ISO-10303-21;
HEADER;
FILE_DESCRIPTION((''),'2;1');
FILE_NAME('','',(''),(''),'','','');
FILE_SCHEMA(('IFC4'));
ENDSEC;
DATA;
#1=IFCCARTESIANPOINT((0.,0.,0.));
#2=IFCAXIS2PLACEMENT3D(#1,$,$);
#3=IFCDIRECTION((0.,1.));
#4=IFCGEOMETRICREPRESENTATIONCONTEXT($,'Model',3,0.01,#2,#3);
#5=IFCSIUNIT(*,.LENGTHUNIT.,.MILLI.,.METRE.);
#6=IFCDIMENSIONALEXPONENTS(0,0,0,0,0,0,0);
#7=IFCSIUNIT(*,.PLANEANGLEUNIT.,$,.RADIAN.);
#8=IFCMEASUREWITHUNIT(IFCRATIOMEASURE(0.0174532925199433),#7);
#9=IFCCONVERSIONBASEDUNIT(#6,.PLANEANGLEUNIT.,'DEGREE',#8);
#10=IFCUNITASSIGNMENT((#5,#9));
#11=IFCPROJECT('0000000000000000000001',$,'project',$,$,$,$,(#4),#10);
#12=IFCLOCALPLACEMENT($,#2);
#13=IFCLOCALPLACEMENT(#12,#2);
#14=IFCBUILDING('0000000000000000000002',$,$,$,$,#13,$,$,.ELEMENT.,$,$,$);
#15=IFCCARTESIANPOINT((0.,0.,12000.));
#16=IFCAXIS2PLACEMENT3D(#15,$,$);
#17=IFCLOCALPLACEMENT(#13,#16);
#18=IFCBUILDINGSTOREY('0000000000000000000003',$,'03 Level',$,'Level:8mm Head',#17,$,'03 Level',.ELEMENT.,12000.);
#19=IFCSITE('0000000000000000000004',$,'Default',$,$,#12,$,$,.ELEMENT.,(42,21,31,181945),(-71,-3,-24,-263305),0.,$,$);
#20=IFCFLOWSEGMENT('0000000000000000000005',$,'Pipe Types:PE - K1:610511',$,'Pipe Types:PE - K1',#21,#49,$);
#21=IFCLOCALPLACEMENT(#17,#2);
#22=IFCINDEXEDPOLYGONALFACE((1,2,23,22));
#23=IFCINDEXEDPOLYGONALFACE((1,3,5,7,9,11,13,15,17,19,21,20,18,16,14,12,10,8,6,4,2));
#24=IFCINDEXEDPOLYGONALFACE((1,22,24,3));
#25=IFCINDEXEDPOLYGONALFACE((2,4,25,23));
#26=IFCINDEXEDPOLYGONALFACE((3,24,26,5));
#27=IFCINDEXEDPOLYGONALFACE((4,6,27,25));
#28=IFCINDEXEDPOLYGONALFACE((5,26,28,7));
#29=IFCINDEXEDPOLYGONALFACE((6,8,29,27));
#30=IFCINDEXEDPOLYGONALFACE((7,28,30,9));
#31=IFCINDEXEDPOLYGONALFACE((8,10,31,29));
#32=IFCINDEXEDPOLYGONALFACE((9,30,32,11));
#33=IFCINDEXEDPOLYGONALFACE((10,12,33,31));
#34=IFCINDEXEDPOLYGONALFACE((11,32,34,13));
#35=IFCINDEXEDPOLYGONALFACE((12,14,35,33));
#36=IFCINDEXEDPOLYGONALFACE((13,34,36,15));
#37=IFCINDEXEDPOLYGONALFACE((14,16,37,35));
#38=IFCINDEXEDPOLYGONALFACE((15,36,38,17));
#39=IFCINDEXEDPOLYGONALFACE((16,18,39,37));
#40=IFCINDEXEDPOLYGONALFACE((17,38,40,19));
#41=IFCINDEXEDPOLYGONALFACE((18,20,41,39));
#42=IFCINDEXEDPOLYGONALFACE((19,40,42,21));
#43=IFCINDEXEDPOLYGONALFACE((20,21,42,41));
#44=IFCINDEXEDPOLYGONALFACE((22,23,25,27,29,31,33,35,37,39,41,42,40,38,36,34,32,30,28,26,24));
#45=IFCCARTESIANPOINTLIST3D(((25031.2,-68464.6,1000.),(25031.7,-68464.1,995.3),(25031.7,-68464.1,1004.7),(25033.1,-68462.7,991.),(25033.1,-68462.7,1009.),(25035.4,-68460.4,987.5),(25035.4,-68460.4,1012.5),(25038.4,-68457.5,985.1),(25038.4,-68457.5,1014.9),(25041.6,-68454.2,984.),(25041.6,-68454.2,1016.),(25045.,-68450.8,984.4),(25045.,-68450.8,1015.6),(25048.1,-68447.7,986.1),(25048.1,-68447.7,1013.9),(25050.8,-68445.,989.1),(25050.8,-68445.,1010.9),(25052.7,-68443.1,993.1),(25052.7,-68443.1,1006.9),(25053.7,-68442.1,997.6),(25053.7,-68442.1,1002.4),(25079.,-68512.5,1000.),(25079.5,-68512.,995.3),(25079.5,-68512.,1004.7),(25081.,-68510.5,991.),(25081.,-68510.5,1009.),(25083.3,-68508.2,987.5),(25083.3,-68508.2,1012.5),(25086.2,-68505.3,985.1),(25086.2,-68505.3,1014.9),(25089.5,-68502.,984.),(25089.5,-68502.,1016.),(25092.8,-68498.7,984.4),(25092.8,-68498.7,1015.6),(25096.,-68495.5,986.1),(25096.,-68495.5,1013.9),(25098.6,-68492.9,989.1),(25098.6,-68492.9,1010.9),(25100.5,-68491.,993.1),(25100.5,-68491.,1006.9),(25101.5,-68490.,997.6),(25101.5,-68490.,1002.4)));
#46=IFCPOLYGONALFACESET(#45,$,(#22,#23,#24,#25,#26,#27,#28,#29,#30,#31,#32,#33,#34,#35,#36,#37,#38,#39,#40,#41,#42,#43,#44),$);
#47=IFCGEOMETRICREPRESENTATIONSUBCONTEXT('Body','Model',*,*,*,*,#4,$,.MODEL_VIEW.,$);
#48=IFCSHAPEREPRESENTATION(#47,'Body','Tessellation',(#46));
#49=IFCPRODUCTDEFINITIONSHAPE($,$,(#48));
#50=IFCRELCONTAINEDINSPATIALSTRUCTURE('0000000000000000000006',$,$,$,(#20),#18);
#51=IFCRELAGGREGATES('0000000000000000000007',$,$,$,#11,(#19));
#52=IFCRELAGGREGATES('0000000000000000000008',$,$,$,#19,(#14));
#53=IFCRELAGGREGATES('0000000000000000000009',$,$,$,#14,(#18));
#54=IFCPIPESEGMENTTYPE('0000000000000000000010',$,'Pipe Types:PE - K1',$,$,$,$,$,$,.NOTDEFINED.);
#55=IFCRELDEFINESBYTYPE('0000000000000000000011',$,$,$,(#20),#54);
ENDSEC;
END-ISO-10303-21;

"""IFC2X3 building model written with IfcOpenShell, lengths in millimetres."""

from ifc_helpers import new_model, entity, si_unit, converted_unit, direction, frame, frame_2d, origin, place, context, subcontext, project, spatial, circle, extrude, type_object, element, save


model = new_model("IFC2X3")

# Units and contexts
model_context = context("Model", 3, precision=0.01, world=origin(), true_north=direction((0.0, 1.0)))
body_context = subcontext(model_context, "Body", "Model", "MODEL_VIEW")
ifc_project = project(units=[si_unit("LENGTHUNIT", "METRE", prefix="MILLI"), converted_unit("PLANEANGLEUNIT", "DEGREE", entity("IfcRatioMeasure", 0.0174532925199433), si_unit("PLANEANGLEUNIT", "RADIAN"), dimensions=[0, 0, 0, 0, 0, 0, 0])], contexts=[model_context])

# Site, building, storey
site_placement = place(None, origin())
site = spatial("IfcSite", under=ifc_project, at=site_placement, Name="Default", CompositionType="ELEMENT", RefLatitude=(42, 21, 31, 181945), RefLongitude=(-71, -3, -24, -263305), RefElevation=0.0)
building_placement = place(site_placement, origin())
building = spatial("IfcBuilding", under=site, at=building_placement, CompositionType="ELEMENT")
storey_placement = place(building_placement, frame((0.0, 0.0, 12000.0)))
storey = spatial("IfcBuildingStorey", under=building, at=storey_placement, Name="03 Level", ObjectType="Level:8mm Head", LongName="03 Level", CompositionType="ELEMENT", Elevation=12000.0)

# Flow segment
pipe_segment_type = type_object("IfcPipeSegmentType", Name="Pipe Types:PE - K1", PredefinedType="NOTDEFINED")
flow_segment_1_placement = place(storey_placement, frame((25029.6, -68514.1, 982.4)))
element("IfcFlowSegment", 1, at=flow_segment_1_placement, inside=storey, type_object=pipe_segment_type, Name="Pipe Types:PE - K1:610511", ObjectType="Pipe Types:PE - K1", context=body_context, shape_type="SweptSolid", body=[
    extrude(circle(Radius=16.0, at=frame_2d((0.0, 0.0), x_axis=(1.0, 0.0))), frame((60.7, 12.9, 17.6), z_axis=(-0.707107, 0.707107, 0.0), x_axis=(-0.707107, -0.707107, 0.0)), (0.0, 0.0, 1.0), 67.6),
])

save(model, "model.ifc")
